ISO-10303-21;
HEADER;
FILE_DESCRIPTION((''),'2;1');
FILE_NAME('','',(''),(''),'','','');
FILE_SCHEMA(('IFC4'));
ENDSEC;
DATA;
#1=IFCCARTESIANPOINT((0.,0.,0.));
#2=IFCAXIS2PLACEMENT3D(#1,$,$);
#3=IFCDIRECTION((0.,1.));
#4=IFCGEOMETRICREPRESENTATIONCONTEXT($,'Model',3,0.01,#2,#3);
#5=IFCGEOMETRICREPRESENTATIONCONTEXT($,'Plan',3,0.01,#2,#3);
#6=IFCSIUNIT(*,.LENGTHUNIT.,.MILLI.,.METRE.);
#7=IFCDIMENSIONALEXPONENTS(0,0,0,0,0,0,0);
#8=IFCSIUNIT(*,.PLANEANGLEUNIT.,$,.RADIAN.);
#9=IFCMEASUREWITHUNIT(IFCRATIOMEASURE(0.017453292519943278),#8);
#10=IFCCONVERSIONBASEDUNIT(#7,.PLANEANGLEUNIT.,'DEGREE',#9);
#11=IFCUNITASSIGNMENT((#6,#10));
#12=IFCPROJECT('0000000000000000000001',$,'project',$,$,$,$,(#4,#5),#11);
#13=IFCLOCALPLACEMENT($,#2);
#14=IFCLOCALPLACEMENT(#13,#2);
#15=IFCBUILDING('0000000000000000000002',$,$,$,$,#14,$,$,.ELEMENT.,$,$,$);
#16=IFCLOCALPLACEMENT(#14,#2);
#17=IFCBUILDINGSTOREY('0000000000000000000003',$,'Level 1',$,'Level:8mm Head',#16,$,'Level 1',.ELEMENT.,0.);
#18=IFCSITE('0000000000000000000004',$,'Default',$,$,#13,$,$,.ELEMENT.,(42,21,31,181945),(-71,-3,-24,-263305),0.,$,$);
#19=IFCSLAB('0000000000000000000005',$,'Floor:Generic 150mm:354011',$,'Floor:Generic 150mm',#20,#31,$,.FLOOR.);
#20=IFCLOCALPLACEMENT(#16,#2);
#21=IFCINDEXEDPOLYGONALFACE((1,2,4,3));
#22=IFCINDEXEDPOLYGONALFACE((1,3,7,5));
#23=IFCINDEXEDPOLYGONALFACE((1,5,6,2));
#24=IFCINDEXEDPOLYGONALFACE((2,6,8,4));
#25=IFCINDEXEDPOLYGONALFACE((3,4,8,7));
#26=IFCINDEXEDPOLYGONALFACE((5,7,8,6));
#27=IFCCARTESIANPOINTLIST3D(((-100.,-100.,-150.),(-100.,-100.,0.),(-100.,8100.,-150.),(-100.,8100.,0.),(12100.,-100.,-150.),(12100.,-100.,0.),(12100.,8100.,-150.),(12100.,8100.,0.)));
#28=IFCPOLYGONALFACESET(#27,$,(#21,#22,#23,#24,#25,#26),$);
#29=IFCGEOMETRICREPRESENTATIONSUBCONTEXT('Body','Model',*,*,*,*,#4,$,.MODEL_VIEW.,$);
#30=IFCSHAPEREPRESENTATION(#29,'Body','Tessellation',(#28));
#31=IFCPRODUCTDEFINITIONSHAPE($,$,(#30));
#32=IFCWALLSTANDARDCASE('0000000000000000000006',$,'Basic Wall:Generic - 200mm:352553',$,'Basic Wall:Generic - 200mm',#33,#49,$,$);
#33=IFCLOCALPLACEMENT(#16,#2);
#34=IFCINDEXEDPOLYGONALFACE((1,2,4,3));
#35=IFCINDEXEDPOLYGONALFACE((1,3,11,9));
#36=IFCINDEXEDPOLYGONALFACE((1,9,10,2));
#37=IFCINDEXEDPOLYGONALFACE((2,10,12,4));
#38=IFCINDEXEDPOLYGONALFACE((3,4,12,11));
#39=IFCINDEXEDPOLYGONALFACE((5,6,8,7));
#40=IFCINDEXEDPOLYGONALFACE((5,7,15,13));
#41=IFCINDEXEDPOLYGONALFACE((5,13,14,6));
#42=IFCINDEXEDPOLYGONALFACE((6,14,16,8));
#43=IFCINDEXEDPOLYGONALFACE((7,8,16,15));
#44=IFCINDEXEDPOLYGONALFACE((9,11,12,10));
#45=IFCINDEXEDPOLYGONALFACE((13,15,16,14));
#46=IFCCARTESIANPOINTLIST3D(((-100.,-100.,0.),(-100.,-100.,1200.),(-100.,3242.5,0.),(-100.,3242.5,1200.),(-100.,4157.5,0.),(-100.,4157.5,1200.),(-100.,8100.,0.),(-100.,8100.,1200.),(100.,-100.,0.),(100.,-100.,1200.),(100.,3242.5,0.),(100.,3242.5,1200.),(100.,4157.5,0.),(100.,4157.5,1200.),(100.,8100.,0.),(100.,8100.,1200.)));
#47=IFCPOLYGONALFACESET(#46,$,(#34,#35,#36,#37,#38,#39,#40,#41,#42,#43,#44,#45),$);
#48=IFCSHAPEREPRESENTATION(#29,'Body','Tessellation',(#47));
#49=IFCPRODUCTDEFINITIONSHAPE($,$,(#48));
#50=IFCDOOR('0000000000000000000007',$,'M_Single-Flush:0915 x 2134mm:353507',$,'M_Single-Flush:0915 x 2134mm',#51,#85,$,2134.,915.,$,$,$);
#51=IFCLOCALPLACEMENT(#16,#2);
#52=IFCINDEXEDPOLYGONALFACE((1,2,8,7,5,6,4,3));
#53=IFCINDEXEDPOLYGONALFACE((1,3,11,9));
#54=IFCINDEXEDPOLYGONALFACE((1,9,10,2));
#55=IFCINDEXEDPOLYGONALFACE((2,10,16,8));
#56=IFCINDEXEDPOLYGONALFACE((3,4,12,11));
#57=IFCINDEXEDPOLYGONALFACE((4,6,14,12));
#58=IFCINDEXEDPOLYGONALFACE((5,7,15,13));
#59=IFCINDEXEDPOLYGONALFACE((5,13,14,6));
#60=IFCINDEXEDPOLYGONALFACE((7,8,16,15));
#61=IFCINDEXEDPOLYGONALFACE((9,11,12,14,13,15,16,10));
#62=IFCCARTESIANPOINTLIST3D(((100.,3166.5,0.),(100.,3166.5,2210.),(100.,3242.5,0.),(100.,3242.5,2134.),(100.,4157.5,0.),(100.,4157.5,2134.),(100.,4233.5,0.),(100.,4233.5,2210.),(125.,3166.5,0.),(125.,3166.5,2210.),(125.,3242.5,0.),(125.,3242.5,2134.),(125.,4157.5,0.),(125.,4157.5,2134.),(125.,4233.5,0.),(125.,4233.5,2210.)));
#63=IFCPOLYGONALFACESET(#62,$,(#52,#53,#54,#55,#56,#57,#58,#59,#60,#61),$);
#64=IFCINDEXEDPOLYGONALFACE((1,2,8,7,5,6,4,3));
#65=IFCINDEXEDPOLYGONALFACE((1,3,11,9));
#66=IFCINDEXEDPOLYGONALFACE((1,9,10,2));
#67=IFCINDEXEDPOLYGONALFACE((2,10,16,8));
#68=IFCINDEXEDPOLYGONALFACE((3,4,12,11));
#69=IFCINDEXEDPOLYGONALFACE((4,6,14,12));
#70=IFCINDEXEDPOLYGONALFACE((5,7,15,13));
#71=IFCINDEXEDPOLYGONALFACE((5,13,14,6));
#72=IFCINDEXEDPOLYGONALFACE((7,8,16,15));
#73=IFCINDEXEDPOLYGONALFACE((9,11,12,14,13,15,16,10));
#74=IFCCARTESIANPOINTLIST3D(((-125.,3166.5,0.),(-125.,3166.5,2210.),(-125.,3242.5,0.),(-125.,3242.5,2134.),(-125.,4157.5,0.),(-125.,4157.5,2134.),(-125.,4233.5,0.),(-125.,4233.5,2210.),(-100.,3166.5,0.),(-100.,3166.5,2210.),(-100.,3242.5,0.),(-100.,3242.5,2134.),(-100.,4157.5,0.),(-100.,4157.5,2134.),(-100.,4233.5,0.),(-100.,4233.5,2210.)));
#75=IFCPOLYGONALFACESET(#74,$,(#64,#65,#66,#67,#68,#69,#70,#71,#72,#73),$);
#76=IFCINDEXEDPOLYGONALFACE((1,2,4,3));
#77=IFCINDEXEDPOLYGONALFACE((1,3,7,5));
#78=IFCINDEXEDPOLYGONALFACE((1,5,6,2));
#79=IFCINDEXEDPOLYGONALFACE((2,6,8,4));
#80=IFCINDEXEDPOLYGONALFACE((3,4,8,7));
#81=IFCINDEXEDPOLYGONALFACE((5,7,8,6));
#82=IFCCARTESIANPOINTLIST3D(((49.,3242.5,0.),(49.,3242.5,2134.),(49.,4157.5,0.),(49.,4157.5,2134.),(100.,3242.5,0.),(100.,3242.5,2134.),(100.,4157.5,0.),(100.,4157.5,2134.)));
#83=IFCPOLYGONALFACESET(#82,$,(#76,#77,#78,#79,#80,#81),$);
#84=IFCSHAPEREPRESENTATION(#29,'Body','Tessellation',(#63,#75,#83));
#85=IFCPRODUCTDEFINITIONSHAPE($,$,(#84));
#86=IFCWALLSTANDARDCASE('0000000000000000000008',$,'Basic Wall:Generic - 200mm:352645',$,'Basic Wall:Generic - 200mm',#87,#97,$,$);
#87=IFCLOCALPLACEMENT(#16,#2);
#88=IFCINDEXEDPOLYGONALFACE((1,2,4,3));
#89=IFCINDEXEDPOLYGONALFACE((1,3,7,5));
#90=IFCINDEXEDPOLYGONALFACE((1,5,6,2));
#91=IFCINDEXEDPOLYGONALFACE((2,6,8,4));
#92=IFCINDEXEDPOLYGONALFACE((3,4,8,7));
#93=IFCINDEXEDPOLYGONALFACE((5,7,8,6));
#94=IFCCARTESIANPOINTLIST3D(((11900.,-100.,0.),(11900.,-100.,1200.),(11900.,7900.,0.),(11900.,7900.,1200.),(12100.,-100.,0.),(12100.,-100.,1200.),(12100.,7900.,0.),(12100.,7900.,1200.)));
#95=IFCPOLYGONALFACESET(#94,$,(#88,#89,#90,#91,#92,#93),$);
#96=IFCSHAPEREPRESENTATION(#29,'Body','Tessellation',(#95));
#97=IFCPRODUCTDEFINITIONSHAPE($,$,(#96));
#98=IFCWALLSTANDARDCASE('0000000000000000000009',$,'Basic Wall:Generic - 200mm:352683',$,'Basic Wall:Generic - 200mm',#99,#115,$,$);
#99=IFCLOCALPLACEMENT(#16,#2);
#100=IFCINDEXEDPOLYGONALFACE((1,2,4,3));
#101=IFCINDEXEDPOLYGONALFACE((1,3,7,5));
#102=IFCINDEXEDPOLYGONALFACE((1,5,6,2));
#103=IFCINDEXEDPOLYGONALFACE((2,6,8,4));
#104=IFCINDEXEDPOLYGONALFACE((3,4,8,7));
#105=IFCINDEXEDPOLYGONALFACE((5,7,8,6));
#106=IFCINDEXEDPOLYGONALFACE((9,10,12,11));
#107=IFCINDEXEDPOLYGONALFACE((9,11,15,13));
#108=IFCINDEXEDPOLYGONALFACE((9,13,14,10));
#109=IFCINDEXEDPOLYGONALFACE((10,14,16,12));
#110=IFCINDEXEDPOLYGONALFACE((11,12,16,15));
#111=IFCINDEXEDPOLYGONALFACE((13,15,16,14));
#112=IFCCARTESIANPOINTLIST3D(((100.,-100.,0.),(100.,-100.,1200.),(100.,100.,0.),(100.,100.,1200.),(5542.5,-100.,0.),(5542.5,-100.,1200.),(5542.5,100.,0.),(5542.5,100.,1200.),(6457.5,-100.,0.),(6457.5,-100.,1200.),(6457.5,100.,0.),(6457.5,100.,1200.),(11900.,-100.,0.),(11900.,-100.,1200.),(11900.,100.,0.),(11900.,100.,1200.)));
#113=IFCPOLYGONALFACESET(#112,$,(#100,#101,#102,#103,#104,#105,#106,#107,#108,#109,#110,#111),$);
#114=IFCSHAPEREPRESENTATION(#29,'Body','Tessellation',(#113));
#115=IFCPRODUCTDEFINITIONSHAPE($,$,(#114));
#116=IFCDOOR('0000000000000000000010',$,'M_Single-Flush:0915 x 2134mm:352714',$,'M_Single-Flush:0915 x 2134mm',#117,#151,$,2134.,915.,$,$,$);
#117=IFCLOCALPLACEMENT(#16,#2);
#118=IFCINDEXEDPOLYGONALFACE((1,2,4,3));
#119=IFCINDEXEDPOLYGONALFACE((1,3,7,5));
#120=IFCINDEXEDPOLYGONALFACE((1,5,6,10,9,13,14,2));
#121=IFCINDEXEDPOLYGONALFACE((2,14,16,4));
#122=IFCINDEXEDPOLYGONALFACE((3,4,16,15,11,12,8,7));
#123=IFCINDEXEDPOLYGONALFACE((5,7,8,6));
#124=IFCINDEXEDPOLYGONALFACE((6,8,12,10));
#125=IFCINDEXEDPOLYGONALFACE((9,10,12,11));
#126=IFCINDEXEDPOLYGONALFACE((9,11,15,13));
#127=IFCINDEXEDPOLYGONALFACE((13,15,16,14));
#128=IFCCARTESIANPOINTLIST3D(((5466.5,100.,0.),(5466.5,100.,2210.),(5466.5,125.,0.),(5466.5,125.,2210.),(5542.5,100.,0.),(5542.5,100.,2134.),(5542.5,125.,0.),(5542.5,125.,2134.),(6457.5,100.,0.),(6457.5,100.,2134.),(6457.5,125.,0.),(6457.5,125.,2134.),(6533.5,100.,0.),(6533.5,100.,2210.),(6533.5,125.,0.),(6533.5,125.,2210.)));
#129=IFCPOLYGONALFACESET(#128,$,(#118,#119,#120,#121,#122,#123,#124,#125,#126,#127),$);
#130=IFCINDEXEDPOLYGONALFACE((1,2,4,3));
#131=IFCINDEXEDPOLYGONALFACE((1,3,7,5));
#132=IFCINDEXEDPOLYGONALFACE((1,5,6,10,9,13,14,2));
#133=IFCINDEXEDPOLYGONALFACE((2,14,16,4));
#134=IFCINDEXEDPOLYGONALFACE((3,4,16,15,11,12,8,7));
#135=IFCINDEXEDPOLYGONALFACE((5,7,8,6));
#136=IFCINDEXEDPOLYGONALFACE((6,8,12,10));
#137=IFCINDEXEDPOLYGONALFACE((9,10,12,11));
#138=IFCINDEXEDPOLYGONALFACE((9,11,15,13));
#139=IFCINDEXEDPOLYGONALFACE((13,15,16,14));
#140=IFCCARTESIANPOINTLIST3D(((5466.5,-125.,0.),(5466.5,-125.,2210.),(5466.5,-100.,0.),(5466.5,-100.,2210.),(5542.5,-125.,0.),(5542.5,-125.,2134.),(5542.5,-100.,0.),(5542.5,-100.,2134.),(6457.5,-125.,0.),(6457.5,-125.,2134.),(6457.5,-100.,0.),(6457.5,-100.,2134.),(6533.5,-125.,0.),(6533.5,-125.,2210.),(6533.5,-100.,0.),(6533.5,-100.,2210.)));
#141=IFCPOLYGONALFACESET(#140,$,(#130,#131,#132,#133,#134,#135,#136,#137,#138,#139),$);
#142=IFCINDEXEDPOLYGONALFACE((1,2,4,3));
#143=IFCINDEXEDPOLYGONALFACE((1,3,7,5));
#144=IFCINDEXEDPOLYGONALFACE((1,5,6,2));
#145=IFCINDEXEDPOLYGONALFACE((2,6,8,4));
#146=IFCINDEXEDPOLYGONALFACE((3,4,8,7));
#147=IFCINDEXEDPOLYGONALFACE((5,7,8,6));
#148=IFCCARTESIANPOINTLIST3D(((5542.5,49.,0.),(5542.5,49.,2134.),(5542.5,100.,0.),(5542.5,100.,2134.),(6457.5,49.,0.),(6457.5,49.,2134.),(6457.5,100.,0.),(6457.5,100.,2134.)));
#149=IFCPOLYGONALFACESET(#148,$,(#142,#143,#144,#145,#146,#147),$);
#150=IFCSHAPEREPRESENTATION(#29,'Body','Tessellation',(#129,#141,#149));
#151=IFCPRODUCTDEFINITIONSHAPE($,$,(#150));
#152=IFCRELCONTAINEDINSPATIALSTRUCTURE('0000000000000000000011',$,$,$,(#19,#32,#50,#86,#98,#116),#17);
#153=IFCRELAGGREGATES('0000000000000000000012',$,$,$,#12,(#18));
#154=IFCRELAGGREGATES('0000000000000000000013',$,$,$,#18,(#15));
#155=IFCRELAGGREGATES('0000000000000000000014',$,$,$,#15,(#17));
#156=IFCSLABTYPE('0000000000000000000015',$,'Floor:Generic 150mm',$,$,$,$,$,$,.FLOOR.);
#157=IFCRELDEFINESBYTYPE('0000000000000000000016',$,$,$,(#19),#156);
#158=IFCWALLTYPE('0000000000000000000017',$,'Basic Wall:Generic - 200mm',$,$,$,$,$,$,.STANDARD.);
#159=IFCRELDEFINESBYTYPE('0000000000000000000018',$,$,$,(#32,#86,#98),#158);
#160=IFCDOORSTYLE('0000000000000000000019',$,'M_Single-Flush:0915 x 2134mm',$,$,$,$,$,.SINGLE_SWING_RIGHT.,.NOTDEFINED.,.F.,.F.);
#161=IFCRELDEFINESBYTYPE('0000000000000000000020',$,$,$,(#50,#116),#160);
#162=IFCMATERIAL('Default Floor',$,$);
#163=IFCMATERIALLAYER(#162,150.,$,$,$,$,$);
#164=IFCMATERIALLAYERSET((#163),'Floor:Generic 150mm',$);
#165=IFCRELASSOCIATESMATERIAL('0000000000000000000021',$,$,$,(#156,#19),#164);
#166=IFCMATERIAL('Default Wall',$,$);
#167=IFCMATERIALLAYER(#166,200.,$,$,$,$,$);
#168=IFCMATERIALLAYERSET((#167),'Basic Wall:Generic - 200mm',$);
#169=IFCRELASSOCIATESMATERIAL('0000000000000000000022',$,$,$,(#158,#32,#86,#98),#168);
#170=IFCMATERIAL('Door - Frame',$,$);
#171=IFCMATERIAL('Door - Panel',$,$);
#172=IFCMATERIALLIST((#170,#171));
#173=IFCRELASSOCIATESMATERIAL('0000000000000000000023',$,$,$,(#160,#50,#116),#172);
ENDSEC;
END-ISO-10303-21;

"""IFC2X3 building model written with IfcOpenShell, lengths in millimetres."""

from ifc_helpers import new_model, entity, si_unit, converted_unit, direction, frame, frame_2d, origin, place, context, subcontext, project, spatial, polyline, rectangle, outline, extrude, clip, bounded_halfspace, source, transform, mapped, material, material_list, layer, layer_set, layer_usage, type_object, type_shapes, element, fill, save


model = new_model("IFC2X3")

# Units and contexts
model_context = context("Model", 3, precision=0.01, world=origin(), true_north=direction((0.0, 1.0)))
plan_context = context("Plan", 3, precision=0.01, world=origin(), true_north=direction((0.0, 1.0)))
body_context = subcontext(model_context, "Body", "Model", "MODEL_VIEW")
ifc_project = project(units=[si_unit("LENGTHUNIT", "METRE", prefix="MILLI"), converted_unit("PLANEANGLEUNIT", "DEGREE", entity("IfcRatioMeasure", 0.017453292519943278), si_unit("PLANEANGLEUNIT", "RADIAN"), dimensions=[0, 0, 0, 0, 0, 0, 0])], contexts=[model_context, plan_context])

# Site, building, storey
site_placement = place(None, origin())
site = spatial("IfcSite", under=ifc_project, at=site_placement, Name="Default", CompositionType="ELEMENT", RefLatitude=(42, 21, 31, 181945), RefLongitude=(-71, -3, -24, -263305), RefElevation=0.0)
building_placement = place(site_placement, origin())
building = spatial("IfcBuilding", under=site, at=building_placement, CompositionType="ELEMENT")
storey_placement = place(building_placement, origin())
storey = spatial("IfcBuildingStorey", under=building, at=storey_placement, Name="Level 1", ObjectType="Level:8mm Head", LongName="Level 1", CompositionType="ELEMENT", Elevation=0.0)

# Slab
ifc_material_1 = material(Name="Default Floor")
ifc_layer_1 = layer(ifc_material_1, 150.0)
ifc_layer_set_1 = layer_set([ifc_layer_1], Name="Floor:Generic 150mm")
ifc_layer_usage_1 = layer_usage(ifc_layer_set_1, "AXIS3", "POSITIVE", 0.0)
slab_type = type_object("IfcSlabType", Name="Floor:Generic 150mm", PredefinedType="FLOOR", material=ifc_layer_set_1)
slab_placement = place(storey_placement, origin())
element("IfcSlab", 1, at=slab_placement, inside=storey, type_object=slab_type, material=ifc_layer_usage_1, Name="Floor:Generic 150mm:354011", ObjectType="Floor:Generic 150mm", PredefinedType="FLOOR", context=body_context, shape_type="SweptSolid", body=[
    extrude(rectangle(XDim=8200.0, YDim=12200.0, at=frame_2d((0.0, 0.0), x_axis=(1.0, 0.0))), frame((6000.0, 4000.0, 0.0), z_axis=(0.0, 0.0, -1.0), x_axis=(0.0, 1.0, 0.0)), (0.0, 0.0, 1.0), 150.0),
])

# Wall, opening, door
ifc_material_2 = material(Name="Default Wall")
ifc_layer_2 = layer(ifc_material_2, 200.0)
ifc_layer_set_2 = layer_set([ifc_layer_2], Name="Basic Wall:Generic - 200mm")
ifc_layer_usage_2 = layer_usage(ifc_layer_set_2, "AXIS2", "NEGATIVE", 100.0)
wall_type = type_object("IfcWallType", Name="Basic Wall:Generic - 200mm", PredefinedType="STANDARD", material=ifc_layer_set_2)
wall_1_placement = place(storey_placement, frame((0.0, -100.0, 0.0), z_axis=(0.0, 0.0, 1.0), x_axis=(0.0, 1.0, 0.0)))
wall_1 = element("IfcWallStandardCase", 2, at=wall_1_placement, inside=storey, type_object=wall_type, material=ifc_layer_usage_2, Name="Basic Wall:Generic - 200mm:352553", ObjectType="Basic Wall:Generic - 200mm", context=body_context, shape_type="Clipping", body=[
    clip(extrude(rectangle(XDim=8200.0, YDim=200.0, at=frame_2d((4100.0, 0.0), x_axis=(1.0, 0.0))), origin(), (0.0, 0.0, 1.0), 1200.0), bounded_halfspace(frame((0.0, -100.0, 3850.0), z_axis=(0.0, 0.0, -1.0), x_axis=(-1.0, 0.0, 0.0)), True, frame((0.0, -100.0, 3850.0)), polyline([(0.0, 0.0), (200.0, 0.0), (2800.0, 0.0), (3000.0, 0.0), (4600.0, 0.0), (4800.0, 0.0), (8000.0, 0.0), (8200.0, 0.0), (8200.0, 200.0), (0.0, 200.0), (0.0, 0.0)]))),
])
opening_1_placement = place(wall_1_placement, frame((4257.5, 100.0, 0.0)))
opening_1 = element("IfcOpeningElement", 3, at=opening_1_placement, cuts=wall_1, ObjectType="Opening", context=body_context, shape_type="SweptSolid", body=[
    extrude(rectangle(XDim=915.0, YDim=2134.0, at=frame_2d((1067.0, 457.5), x_axis=(0.0, 1.0))), frame((0.0, 0.0, 0.0), z_axis=(0.0, -1.0, 0.0), x_axis=(0.0, 0.0, 1.0)), (0.0, 0.0, 1.0), 200.0),
])
ifc_material_3 = material(Name="Door - Frame")
ifc_material_4 = material(Name="Door - Panel")
ifc_material_list = material_list([ifc_material_3, ifc_material_4])
door_style = type_object("IfcDoorStyle", Name="M_Single-Flush:0915 x 2134mm", ConstructionType="NOTDEFINED", OperationType="SINGLE_SWING_RIGHT", ParameterTakesPrecedence=False, Sizeable=False, material=ifc_material_list)
shared_shape = source(origin(), body_context, "Body", "SweptSolid", [
    extrude(outline(polyline([(-533.5, -1124.0), (533.5, -1124.0), (533.5, 1086.0), (457.5, 1086.0), (457.5, -1048.0), (-457.5, -1048.0), (-457.5, 1086.0), (-533.5, 1086.0), (-533.5, -1124.0)])), frame((457.5, 200.0, 1086.0), z_axis=(0.0, 1.0, 0.0), x_axis=(1.0, 0.0, 0.0)), (0.0, 0.0, 1.0), 25.0),
    extrude(outline(polyline([(-1124.0, -533.5), (1086.0, -533.5), (1086.0, -457.5), (-1048.0, -457.5), (-1048.0, 457.5), (1086.0, 457.5), (1086.0, 533.5), (-1124.0, 533.5), (-1124.0, -533.5)])), frame((457.5, -25.0, 1086.0), z_axis=(0.0, 1.0, 0.0), x_axis=(0.0, 0.0, -1.0)), (0.0, 0.0, 1.0), 25.0),
    extrude(rectangle(XDim=51.0, YDim=915.0, at=frame_2d((0.0, 0.0), x_axis=(1.0, 0.0))), frame((457.5, 174.5, 0.0), z_axis=(0.0, 0.0, 1.0), x_axis=(0.0, 1.0, 0.0)), (0.0, 0.0, 1.0), 2134.0),
])
type_shapes(door_style, [shared_shape])
door_1_placement = place(opening_1_placement, frame((0.0, 0.0, 0.0), z_axis=(0.0, 0.0, 1.0), x_axis=(-1.0, 0.0, 0.0)))
door_1 = element("IfcDoor", 4, at=door_1_placement, inside=storey, type_object=door_style, material=ifc_material_list, Name="M_Single-Flush:0915 x 2134mm:353507", ObjectType="M_Single-Flush:0915 x 2134mm", OverallHeight=2134.0, OverallWidth=915.0, context=body_context, shape_type="MappedRepresentation", body=[
    mapped(shared_shape, transform((0.0, 0.0, 0.0), scale=1.0)),
])
fill(opening_1, door_1)

# Wall
wall_2_placement = place(storey_placement, frame((12000.0, 7900.0, 0.0), z_axis=(0.0, 0.0, 1.0), x_axis=(0.0, -1.0, 0.0)))
element("IfcWallStandardCase", 5, at=wall_2_placement, inside=storey, type_object=wall_type, material=ifc_layer_usage_2, Name="Basic Wall:Generic - 200mm:352645", ObjectType="Basic Wall:Generic - 200mm", context=body_context, shape_type="Clipping", body=[
    clip(extrude(rectangle(XDim=8000.0, YDim=200.0, at=frame_2d((4000.0, 0.0), x_axis=(-1.0, 0.0))), origin(), (0.0, 0.0, 1.0), 1200.0), bounded_halfspace(frame((0.0, -100.0, 3850.0), z_axis=(0.0, 0.0, -1.0), x_axis=(1.0, 0.0, 0.0)), True, frame((0.0, -100.0, 3850.0)), polyline([(0.0, 0.0), (3300.0, 0.0), (7800.0, 0.0), (8000.0, 0.0), (8000.0, 200.0), (0.0, 200.0), (0.0, 0.0)]))),
])

# Wall, opening, door
wall_3_placement = place(storey_placement, frame((11900.0, 0.0, 0.0), z_axis=(0.0, 0.0, 1.0), x_axis=(-1.0, 0.0, 0.0)))
wall_3 = element("IfcWallStandardCase", 6, at=wall_3_placement, inside=storey, type_object=wall_type, material=ifc_layer_usage_2, Name="Basic Wall:Generic - 200mm:352683", ObjectType="Basic Wall:Generic - 200mm", context=body_context, shape_type="Clipping", body=[
    clip(extrude(rectangle(XDim=11800.0, YDim=200.0, at=frame_2d((5900.0, 0.0), x_axis=(1.0, 0.0))), origin(), (0.0, 0.0, 1.0), 1200.0), bounded_halfspace(frame((0.0, -100.0, 3850.0), z_axis=(0.0, 0.0, -1.0), x_axis=(0.0, 1.0, 0.0)), True, frame((0.0, -100.0, 3850.0)), polyline([(0.0, 0.0), (8900.0, 0.0), (9100.0, 0.0), (11800.0, 0.0), (11800.0, 200.0), (0.0, 200.0), (0.0, 0.0)]))),
])
opening_2_placement = place(wall_3_placement, frame((6357.5, 100.0, 0.0)))
opening_2 = element("IfcOpeningElement", 7, at=opening_2_placement, cuts=wall_3, ObjectType="Opening", context=body_context, shape_type="SweptSolid", body=[
    extrude(rectangle(XDim=915.0, YDim=2134.0, at=frame_2d((1067.0, 457.5), x_axis=(0.0, 1.0))), frame((0.0, 0.0, 0.0), z_axis=(0.0, -1.0, 0.0), x_axis=(0.0, 0.0, 1.0)), (0.0, 0.0, 1.0), 200.0),
])
door_2_placement = place(opening_2_placement, frame((0.0, 0.0, 0.0), z_axis=(0.0, 0.0, 1.0), x_axis=(-1.0, 0.0, 0.0)))
door_2 = element("IfcDoor", 8, at=door_2_placement, inside=storey, type_object=door_style, material=ifc_material_list, Name="M_Single-Flush:0915 x 2134mm:352714", ObjectType="M_Single-Flush:0915 x 2134mm", OverallHeight=2134.0, OverallWidth=915.0, context=body_context, shape_type="MappedRepresentation", body=[
    mapped(shared_shape, transform((0.0, 0.0, 0.0), scale=1.0)),
])
fill(opening_2, door_2)

save(model, "model.ifc")
